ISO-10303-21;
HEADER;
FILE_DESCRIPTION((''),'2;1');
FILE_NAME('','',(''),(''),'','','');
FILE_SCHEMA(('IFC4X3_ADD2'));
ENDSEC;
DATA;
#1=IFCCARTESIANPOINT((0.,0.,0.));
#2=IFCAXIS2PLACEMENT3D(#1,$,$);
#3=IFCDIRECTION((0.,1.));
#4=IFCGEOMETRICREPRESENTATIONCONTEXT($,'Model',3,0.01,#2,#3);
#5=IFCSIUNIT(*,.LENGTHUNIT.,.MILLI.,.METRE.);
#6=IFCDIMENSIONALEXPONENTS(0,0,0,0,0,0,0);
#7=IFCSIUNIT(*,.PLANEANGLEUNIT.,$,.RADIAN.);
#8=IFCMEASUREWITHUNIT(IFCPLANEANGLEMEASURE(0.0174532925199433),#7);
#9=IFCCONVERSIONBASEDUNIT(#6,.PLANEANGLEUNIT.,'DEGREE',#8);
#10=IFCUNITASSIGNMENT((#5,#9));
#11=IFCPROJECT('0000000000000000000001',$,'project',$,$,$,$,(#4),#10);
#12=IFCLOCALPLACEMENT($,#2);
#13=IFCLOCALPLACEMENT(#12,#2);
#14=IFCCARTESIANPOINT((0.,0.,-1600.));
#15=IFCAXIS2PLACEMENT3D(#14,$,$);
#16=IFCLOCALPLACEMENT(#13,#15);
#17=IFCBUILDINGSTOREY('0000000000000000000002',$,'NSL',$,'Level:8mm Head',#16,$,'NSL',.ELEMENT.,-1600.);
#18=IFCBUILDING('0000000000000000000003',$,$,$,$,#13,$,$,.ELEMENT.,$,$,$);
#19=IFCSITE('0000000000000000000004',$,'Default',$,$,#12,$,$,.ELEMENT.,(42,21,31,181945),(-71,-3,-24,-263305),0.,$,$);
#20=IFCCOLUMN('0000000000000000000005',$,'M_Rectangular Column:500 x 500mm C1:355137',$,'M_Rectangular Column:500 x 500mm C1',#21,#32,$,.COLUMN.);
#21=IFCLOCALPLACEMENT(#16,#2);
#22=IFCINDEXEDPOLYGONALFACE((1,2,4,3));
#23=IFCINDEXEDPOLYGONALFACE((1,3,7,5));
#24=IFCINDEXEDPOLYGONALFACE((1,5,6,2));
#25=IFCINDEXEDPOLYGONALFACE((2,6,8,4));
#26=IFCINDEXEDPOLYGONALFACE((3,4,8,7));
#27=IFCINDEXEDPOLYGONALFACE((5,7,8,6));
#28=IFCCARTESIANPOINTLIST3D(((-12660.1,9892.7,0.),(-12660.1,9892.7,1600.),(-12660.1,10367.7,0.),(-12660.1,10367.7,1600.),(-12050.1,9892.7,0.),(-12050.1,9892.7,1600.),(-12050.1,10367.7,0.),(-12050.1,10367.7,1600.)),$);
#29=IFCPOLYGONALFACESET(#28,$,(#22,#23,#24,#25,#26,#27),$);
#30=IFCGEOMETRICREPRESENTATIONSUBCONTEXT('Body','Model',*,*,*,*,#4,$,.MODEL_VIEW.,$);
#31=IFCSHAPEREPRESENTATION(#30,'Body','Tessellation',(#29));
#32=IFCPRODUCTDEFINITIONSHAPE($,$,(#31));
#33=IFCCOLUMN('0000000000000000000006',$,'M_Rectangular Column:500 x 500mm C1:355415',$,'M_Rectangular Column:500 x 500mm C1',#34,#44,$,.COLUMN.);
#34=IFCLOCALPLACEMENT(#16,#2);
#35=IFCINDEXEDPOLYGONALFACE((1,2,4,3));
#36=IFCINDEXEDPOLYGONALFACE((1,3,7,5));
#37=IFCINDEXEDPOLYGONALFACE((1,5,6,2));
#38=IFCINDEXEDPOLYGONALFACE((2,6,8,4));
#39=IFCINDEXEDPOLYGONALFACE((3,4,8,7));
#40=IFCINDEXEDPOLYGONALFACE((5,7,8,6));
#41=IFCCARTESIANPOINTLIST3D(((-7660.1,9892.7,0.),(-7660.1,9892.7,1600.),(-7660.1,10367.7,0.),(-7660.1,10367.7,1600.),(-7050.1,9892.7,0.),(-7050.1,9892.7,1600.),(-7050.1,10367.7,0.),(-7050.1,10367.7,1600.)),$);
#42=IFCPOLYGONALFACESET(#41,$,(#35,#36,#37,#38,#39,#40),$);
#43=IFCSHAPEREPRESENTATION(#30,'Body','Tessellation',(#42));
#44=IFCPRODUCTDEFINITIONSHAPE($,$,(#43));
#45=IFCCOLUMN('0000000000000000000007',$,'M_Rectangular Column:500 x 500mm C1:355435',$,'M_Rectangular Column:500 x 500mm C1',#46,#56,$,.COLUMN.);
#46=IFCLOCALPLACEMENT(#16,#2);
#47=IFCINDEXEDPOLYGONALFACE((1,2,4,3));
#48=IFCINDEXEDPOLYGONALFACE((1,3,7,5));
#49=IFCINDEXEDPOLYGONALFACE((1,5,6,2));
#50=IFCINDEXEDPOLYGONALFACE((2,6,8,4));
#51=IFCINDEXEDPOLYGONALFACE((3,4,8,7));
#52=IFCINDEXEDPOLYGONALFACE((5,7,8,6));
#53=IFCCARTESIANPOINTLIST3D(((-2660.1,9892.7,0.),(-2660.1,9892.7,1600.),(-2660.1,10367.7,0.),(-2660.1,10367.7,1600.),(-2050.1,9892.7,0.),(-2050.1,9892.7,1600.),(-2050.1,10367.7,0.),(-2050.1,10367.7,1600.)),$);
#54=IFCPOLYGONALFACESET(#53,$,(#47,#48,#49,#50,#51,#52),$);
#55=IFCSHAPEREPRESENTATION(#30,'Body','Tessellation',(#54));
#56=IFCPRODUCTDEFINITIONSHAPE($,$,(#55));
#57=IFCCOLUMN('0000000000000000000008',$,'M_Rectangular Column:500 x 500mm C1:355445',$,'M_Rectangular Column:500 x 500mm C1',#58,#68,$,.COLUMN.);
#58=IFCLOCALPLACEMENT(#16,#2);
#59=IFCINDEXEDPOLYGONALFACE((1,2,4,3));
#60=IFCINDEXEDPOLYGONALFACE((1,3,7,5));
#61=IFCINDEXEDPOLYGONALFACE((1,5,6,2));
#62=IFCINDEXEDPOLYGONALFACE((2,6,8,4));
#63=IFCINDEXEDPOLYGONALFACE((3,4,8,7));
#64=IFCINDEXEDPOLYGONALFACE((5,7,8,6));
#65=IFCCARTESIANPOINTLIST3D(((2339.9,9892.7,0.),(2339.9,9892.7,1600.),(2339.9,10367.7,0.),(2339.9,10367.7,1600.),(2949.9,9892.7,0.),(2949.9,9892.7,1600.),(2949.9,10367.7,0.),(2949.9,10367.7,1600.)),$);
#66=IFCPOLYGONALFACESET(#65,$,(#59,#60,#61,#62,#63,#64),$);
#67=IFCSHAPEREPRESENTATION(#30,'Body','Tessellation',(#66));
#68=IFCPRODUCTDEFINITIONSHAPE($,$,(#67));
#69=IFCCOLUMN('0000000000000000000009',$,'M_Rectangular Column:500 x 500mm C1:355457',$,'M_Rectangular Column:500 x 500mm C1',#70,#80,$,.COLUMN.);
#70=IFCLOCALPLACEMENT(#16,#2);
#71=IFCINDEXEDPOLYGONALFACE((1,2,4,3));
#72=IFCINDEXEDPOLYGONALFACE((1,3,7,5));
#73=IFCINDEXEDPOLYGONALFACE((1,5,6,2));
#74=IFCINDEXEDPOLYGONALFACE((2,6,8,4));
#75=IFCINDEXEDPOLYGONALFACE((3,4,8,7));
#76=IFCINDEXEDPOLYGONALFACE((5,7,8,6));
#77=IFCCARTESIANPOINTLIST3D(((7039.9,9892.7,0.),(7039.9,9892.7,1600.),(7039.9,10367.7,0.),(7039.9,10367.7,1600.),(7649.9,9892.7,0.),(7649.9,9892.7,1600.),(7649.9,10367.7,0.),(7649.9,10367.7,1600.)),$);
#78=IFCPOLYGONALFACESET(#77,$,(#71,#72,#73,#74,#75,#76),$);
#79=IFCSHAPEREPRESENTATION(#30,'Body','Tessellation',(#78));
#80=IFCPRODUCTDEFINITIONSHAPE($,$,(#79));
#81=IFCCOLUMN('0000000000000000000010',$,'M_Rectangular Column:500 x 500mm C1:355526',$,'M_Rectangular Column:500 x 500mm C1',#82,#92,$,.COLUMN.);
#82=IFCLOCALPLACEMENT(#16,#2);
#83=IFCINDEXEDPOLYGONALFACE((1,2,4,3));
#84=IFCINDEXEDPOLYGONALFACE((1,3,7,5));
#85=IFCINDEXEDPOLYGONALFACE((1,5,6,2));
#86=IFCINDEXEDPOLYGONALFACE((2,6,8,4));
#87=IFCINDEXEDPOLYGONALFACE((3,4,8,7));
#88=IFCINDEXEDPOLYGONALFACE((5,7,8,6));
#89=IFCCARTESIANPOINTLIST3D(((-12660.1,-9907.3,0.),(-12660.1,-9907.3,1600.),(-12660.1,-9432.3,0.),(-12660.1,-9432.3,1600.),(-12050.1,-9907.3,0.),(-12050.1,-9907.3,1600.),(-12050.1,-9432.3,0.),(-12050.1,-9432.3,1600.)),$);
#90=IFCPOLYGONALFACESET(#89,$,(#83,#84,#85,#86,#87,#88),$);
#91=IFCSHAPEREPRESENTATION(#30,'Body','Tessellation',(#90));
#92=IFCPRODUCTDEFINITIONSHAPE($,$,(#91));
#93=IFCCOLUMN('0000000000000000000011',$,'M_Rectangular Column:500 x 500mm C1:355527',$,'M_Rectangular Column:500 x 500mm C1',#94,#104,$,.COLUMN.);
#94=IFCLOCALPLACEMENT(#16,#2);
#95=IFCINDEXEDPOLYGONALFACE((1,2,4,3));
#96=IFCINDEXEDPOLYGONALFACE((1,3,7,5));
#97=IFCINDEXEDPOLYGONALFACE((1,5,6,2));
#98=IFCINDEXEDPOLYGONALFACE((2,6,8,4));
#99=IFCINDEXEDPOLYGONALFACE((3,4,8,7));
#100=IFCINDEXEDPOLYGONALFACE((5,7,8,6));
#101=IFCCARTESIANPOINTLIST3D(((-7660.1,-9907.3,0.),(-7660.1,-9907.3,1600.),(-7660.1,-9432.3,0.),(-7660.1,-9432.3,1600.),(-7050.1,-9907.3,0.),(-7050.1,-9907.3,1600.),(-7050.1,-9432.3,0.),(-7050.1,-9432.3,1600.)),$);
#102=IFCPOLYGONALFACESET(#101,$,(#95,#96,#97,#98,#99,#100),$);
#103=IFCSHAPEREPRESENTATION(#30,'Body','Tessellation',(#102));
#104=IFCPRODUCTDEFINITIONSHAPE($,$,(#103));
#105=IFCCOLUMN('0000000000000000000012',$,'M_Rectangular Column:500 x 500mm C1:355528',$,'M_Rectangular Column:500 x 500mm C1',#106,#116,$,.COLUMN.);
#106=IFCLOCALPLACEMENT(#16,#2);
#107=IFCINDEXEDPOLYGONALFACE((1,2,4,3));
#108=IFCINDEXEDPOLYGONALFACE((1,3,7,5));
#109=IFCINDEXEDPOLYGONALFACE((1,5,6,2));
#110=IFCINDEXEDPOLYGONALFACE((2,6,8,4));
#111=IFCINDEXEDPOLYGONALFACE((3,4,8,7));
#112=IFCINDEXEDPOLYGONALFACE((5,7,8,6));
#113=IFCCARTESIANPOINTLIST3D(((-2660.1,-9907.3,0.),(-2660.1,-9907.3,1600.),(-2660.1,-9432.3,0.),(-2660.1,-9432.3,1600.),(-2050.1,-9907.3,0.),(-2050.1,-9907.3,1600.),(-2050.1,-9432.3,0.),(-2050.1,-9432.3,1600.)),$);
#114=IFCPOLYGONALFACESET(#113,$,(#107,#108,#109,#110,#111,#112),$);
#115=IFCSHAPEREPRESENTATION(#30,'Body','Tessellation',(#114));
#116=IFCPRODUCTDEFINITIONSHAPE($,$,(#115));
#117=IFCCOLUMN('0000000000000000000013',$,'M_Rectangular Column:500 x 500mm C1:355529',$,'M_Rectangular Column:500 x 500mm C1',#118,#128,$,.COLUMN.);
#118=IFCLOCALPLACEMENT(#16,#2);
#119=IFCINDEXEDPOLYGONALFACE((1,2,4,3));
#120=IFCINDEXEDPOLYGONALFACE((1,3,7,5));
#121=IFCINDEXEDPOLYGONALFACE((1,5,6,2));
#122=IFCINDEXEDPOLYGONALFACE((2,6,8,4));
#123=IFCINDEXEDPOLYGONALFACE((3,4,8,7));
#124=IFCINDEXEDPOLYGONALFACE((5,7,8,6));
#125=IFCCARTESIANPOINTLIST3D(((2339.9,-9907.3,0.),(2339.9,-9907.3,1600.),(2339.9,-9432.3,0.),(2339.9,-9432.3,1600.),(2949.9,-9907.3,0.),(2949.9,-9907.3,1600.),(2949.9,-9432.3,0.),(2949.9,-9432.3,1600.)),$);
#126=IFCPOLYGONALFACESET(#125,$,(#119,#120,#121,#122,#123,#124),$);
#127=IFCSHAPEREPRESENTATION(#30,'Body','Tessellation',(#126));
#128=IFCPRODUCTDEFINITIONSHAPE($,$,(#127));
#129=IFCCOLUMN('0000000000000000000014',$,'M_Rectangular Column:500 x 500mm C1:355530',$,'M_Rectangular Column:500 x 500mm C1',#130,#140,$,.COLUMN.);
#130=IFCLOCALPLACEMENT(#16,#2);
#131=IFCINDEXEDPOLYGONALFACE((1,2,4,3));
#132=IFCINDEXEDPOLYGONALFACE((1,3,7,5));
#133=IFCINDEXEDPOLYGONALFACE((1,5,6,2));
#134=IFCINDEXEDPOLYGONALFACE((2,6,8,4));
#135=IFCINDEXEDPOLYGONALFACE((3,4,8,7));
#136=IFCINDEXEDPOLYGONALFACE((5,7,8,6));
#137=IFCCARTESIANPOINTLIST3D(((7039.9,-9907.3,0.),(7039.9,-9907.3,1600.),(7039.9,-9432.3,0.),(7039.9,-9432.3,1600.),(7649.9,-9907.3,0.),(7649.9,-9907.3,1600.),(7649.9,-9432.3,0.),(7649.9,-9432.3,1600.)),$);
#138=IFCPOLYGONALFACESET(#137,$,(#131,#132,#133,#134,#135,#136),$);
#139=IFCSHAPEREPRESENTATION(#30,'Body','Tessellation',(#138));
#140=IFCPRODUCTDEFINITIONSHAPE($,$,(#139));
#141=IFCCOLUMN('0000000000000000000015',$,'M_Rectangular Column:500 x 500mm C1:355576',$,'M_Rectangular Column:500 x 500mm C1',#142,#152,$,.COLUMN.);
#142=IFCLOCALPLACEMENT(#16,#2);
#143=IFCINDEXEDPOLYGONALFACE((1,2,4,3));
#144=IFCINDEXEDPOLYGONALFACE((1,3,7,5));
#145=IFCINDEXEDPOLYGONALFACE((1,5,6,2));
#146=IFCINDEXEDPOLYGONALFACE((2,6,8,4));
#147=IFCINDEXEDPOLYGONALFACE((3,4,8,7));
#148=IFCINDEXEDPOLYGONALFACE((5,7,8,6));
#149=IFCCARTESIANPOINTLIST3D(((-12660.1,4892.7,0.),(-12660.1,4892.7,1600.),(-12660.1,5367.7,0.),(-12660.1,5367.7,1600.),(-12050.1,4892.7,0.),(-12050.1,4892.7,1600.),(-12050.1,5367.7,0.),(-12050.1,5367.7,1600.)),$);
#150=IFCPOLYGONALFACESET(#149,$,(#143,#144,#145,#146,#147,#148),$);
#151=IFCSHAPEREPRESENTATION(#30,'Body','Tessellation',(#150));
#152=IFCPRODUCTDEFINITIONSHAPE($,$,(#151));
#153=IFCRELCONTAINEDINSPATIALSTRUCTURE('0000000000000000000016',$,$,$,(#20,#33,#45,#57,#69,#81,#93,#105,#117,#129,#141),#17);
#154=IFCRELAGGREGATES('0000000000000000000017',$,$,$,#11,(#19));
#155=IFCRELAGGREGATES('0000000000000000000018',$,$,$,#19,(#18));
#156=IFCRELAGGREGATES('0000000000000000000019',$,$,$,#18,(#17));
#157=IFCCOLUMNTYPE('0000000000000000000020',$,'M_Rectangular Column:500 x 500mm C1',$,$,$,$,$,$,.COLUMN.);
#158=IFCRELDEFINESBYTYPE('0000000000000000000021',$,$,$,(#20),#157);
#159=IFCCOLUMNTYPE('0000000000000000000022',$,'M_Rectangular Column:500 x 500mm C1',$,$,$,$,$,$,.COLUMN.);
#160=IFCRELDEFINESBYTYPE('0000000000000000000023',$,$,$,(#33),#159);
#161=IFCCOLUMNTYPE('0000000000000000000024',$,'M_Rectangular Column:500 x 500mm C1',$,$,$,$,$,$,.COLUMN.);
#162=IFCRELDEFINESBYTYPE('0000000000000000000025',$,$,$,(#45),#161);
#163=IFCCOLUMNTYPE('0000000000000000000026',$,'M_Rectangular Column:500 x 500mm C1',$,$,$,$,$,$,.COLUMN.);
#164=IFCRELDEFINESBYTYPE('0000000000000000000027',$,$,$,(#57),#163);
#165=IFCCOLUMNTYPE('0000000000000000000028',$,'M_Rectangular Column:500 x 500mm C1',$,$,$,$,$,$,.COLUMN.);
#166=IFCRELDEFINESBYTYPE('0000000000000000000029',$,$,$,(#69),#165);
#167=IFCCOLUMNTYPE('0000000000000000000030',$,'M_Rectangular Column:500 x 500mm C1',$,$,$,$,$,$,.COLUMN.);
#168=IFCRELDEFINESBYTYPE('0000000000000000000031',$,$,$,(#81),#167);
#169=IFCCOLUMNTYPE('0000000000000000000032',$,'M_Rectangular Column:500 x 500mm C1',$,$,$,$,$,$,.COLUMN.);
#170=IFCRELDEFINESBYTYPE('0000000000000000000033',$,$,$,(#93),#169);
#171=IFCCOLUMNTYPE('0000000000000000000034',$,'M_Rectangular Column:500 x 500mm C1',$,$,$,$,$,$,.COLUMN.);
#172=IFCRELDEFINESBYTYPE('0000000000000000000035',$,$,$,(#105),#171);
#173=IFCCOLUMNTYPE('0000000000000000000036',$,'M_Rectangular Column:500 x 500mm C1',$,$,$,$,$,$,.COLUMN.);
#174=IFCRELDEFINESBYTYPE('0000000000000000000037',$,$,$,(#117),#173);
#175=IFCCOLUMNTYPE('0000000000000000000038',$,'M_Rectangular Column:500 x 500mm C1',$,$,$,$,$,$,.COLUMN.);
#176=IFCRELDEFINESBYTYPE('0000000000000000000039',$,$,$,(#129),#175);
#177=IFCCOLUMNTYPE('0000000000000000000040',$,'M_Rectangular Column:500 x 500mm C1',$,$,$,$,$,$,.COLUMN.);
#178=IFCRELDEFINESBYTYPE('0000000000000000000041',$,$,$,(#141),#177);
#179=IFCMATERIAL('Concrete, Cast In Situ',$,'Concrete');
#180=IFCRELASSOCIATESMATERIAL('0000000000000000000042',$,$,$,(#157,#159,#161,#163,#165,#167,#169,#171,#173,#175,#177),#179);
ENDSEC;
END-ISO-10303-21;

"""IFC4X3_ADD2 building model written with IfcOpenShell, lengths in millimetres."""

from ifc_helpers import new_model, entity, si_unit, converted_unit, direction, frame, frame_2d, origin, origin_2d_with_axis, place, context, subcontext, project, spatial, rectangle, extrude, source, transform, mapped, material, material_profile, profile_set, type_object, type_shapes, element, save


model = new_model("IFC4X3_ADD2")

# Units and contexts
model_context = context("Model", 3, precision=0.01, world=origin(), true_north=direction((0.0, 1.0)))
body_context = subcontext(model_context, "Body", "Model", "MODEL_VIEW")
ifc_project = project(units=[si_unit("LENGTHUNIT", "METRE", prefix="MILLI"), converted_unit("PLANEANGLEUNIT", "DEGREE", entity("IfcPlaneAngleMeasure", 0.0174532925199433), si_unit("PLANEANGLEUNIT", "RADIAN"), dimensions=[0, 0, 0, 0, 0, 0, 0])], contexts=[model_context])

# Site, building, storey
site_placement = place(None, origin())
site = spatial("IfcSite", under=ifc_project, at=site_placement, Name="Default", CompositionType="ELEMENT", RefLatitude=(42, 21, 31, 181945), RefLongitude=(-71, -3, -24, -263305), RefElevation=0.0)
building_placement = place(site_placement, origin())
building = spatial("IfcBuilding", under=site, at=building_placement, CompositionType="ELEMENT")
storey_placement = place(building_placement, frame((0.0, 0.0, -1600.0)))
storey = spatial("IfcBuildingStorey", under=building, at=storey_placement, Name="NSL", ObjectType="Level:8mm Head", LongName="NSL", CompositionType="ELEMENT", Elevation=-1600.0)

# Columns
ifc_material_1 = material(Name="Concrete, Cast In Situ", Category="Concrete")
ifc_material_profile_1 = material_profile(ifc_material_1, rectangle(XDim=610.0, YDim=475.0, at=frame_2d((0.0, 0.0), x_axis=(1.0, 0.0))), Name="500 x 500mm C1")
ifc_profile_set_1 = profile_set([ifc_material_profile_1], Name="500 x 500mm C1")
column_type_1 = type_object("IfcColumnType", Name="M_Rectangular Column:500 x 500mm C1", PredefinedType="COLUMN", material=ifc_profile_set_1)
shared_shape_1 = source(origin(), body_context, "Body", "SweptSolid", [
    extrude(rectangle(XDim=610.0, YDim=475.0, at=frame_2d((0.0, 0.0), x_axis=(1.0, 0.0))), frame((-12355.1, 10130.2, -1600.0), z_axis=(0.0, 0.0, 1.0), x_axis=(-1.0, 0.0, 0.0)), (0.0, 0.0, 1.0), 1600.0),
])
type_shapes(column_type_1, [shared_shape_1])
column_1_placement = place(storey_placement, frame((0.0, 0.0, 1600.0)))
element("IfcColumn", 1, at=column_1_placement, inside=storey, type_object=column_type_1, Name="M_Rectangular Column:500 x 500mm C1:355137", ObjectType="M_Rectangular Column:500 x 500mm C1", PredefinedType="COLUMN", context=body_context, shape_type="MappedRepresentation", body=[
    mapped(shared_shape_1, transform((0.0, 0.0, 0.0), scale=1.0)),
])
column_type_2 = type_object("IfcColumnType", Name="M_Rectangular Column:500 x 500mm C1", PredefinedType="COLUMN", material=ifc_profile_set_1)
shared_shape_2 = source(origin(), body_context, "Body", "SweptSolid", [
    extrude(rectangle(XDim=610.0, YDim=475.0, at=frame_2d((0.0, 0.0), x_axis=(1.0, 0.0))), frame((-7355.1, 10130.2, -1600.0), z_axis=(0.0, 0.0, 1.0), x_axis=(-1.0, 0.0, 0.0)), (0.0, 0.0, 1.0), 1600.0),
])
type_shapes(column_type_2, [shared_shape_2])
column_2_placement = place(storey_placement, frame((0.0, 0.0, 1600.0)))
element("IfcColumn", 2, at=column_2_placement, inside=storey, type_object=column_type_2, Name="M_Rectangular Column:500 x 500mm C1:355415", ObjectType="M_Rectangular Column:500 x 500mm C1", PredefinedType="COLUMN", context=body_context, shape_type="MappedRepresentation", body=[
    mapped(shared_shape_2, transform((0.0, 0.0, 0.0), scale=1.0)),
])
column_type_3 = type_object("IfcColumnType", Name="M_Rectangular Column:500 x 500mm C1", PredefinedType="COLUMN", material=ifc_profile_set_1)
shared_shape_3 = source(origin(), body_context, "Body", "SweptSolid", [
    extrude(rectangle(XDim=610.0, YDim=475.0, at=frame_2d((0.0, 0.0), x_axis=(1.0, 0.0))), frame((-2355.1, 10130.2, -1600.0), z_axis=(0.0, 0.0, 1.0), x_axis=(-1.0, 0.0, 0.0)), (0.0, 0.0, 1.0), 1600.0),
])
type_shapes(column_type_3, [shared_shape_3])
column_3_placement = place(storey_placement, frame((0.0, 0.0, 1600.0)))
element("IfcColumn", 3, at=column_3_placement, inside=storey, type_object=column_type_3, Name="M_Rectangular Column:500 x 500mm C1:355435", ObjectType="M_Rectangular Column:500 x 500mm C1", PredefinedType="COLUMN", context=body_context, shape_type="MappedRepresentation", body=[
    mapped(shared_shape_3, transform((0.0, 0.0, 0.0), scale=1.0)),
])
column_type_4 = type_object("IfcColumnType", Name="M_Rectangular Column:500 x 500mm C1", PredefinedType="COLUMN", material=ifc_profile_set_1)
shared_shape_4 = source(origin(), body_context, "Body", "SweptSolid", [
    extrude(rectangle(XDim=610.0, YDim=475.0, at=frame_2d((0.0, 0.0), x_axis=(1.0, 0.0))), frame((2644.9, 10130.2, -1600.0), z_axis=(0.0, 0.0, 1.0), x_axis=(-1.0, 0.0, 0.0)), (0.0, 0.0, 1.0), 1600.0),
])
type_shapes(column_type_4, [shared_shape_4])
column_4_placement = place(storey_placement, frame((0.0, 0.0, 1600.0)))
element("IfcColumn", 4, at=column_4_placement, inside=storey, type_object=column_type_4, Name="M_Rectangular Column:500 x 500mm C1:355445", ObjectType="M_Rectangular Column:500 x 500mm C1", PredefinedType="COLUMN", context=body_context, shape_type="MappedRepresentation", body=[
    mapped(shared_shape_4, transform((0.0, 0.0, 0.0), scale=1.0)),
])
column_type_5 = type_object("IfcColumnType", Name="M_Rectangular Column:500 x 500mm C1", PredefinedType="COLUMN", material=ifc_profile_set_1)
shared_shape_5 = source(origin(), body_context, "Body", "SweptSolid", [
    extrude(rectangle(XDim=610.0, YDim=475.0, at=frame_2d((0.0, 0.0), x_axis=(1.0, 0.0))), frame((7344.9, 10130.2, -1600.0), z_axis=(0.0, 0.0, 1.0), x_axis=(-1.0, 0.0, 0.0)), (0.0, 0.0, 1.0), 1600.0),
])
type_shapes(column_type_5, [shared_shape_5])
column_5_placement = place(storey_placement, frame((0.0, 0.0, 1600.0)))
element("IfcColumn", 5, at=column_5_placement, inside=storey, type_object=column_type_5, Name="M_Rectangular Column:500 x 500mm C1:355457", ObjectType="M_Rectangular Column:500 x 500mm C1", PredefinedType="COLUMN", context=body_context, shape_type="MappedRepresentation", body=[
    mapped(shared_shape_5, transform((0.0, 0.0, 0.0), scale=1.0)),
])
column_type_6 = type_object("IfcColumnType", Name="M_Rectangular Column:500 x 500mm C1", PredefinedType="COLUMN", material=ifc_profile_set_1)
shared_shape_6 = source(origin(), body_context, "Body", "SweptSolid", [
    extrude(rectangle(XDim=610.0, YDim=475.0, at=origin_2d_with_axis()), frame((-12355.1, -9669.8, -1600.0), z_axis=(0.0, 0.0, 1.0), x_axis=(-1.0, 0.0, 0.0)), (0.0, 0.0, 1.0), 1600.0),
])
type_shapes(column_type_6, [shared_shape_6])
column_6_placement = place(storey_placement, frame((0.0, 0.0, 1600.0)))
element("IfcColumn", 6, at=column_6_placement, inside=storey, type_object=column_type_6, Name="M_Rectangular Column:500 x 500mm C1:355526", ObjectType="M_Rectangular Column:500 x 500mm C1", PredefinedType="COLUMN", context=body_context, shape_type="MappedRepresentation", body=[
    mapped(shared_shape_6, transform((0.0, 0.0, 0.0), scale=1.0)),
])
column_type_7 = type_object("IfcColumnType", Name="M_Rectangular Column:500 x 500mm C1", PredefinedType="COLUMN", material=ifc_profile_set_1)
shared_shape_7 = source(origin(), body_context, "Body", "SweptSolid", [
    extrude(rectangle(XDim=610.0, YDim=475.0, at=frame_2d((0.0, 0.0), x_axis=(1.0, 0.0))), frame((-7355.1, -9669.8, -1600.0), z_axis=(0.0, 0.0, 1.0), x_axis=(-1.0, 0.0, 0.0)), (0.0, 0.0, 1.0), 1600.0),
])
type_shapes(column_type_7, [shared_shape_7])
column_7_placement = place(storey_placement, frame((0.0, 0.0, 1600.0)))
element("IfcColumn", 7, at=column_7_placement, inside=storey, type_object=column_type_7, Name="M_Rectangular Column:500 x 500mm C1:355527", ObjectType="M_Rectangular Column:500 x 500mm C1", PredefinedType="COLUMN", context=body_context, shape_type="MappedRepresentation", body=[
    mapped(shared_shape_7, transform((0.0, 0.0, 0.0), scale=1.0)),
])
column_type_8 = type_object("IfcColumnType", Name="M_Rectangular Column:500 x 500mm C1", PredefinedType="COLUMN", material=ifc_profile_set_1)
shared_shape_8 = source(origin(), body_context, "Body", "SweptSolid", [
    extrude(rectangle(XDim=610.0, YDim=475.0, at=frame_2d((0.0, 0.0), x_axis=(1.0, 0.0))), frame((-2355.1, -9669.8, -1600.0), z_axis=(0.0, 0.0, 1.0), x_axis=(-1.0, 0.0, 0.0)), (0.0, 0.0, 1.0), 1600.0),
])
type_shapes(column_type_8, [shared_shape_8])
column_8_placement = place(storey_placement, frame((0.0, 0.0, 1600.0)))
element("IfcColumn", 8, at=column_8_placement, inside=storey, type_object=column_type_8, Name="M_Rectangular Column:500 x 500mm C1:355528", ObjectType="M_Rectangular Column:500 x 500mm C1", PredefinedType="COLUMN", context=body_context, shape_type="MappedRepresentation", body=[
    mapped(shared_shape_8, transform((0.0, 0.0, 0.0), scale=1.0)),
])
column_type_9 = type_object("IfcColumnType", Name="M_Rectangular Column:500 x 500mm C1", PredefinedType="COLUMN", material=ifc_profile_set_1)
shared_shape_9 = source(origin(), body_context, "Body", "SweptSolid", [
    extrude(rectangle(XDim=610.0, YDim=475.0, at=frame_2d((0.0, 0.0), x_axis=(1.0, 0.0))), frame((2644.9, -9669.8, -1600.0), z_axis=(0.0, 0.0, 1.0), x_axis=(-1.0, 0.0, 0.0)), (0.0, 0.0, 1.0), 1600.0),
])
type_shapes(column_type_9, [shared_shape_9])
column_9_placement = place(storey_placement, frame((0.0, 0.0, 1600.0)))
element("IfcColumn", 9, at=column_9_placement, inside=storey, type_object=column_type_9, Name="M_Rectangular Column:500 x 500mm C1:355529", ObjectType="M_Rectangular Column:500 x 500mm C1", PredefinedType="COLUMN", context=body_context, shape_type="MappedRepresentation", body=[
    mapped(shared_shape_9, transform((0.0, 0.0, 0.0), scale=1.0)),
])
column_type_10 = type_object("IfcColumnType", Name="M_Rectangular Column:500 x 500mm C1", PredefinedType="COLUMN", material=ifc_profile_set_1)
shared_shape_10 = source(origin(), body_context, "Body", "SweptSolid", [
    extrude(rectangle(XDim=610.0, YDim=475.0, at=origin_2d_with_axis()), frame((7344.9, -9669.8, -1600.0), z_axis=(0.0, 0.0, 1.0), x_axis=(-1.0, 0.0, 0.0)), (0.0, 0.0, 1.0), 1600.0),
])
type_shapes(column_type_10, [shared_shape_10])
column_10_placement = place(storey_placement, frame((0.0, 0.0, 1600.0)))
element("IfcColumn", 10, at=column_10_placement, inside=storey, type_object=column_type_10, Name="M_Rectangular Column:500 x 500mm C1:355530", ObjectType="M_Rectangular Column:500 x 500mm C1", PredefinedType="COLUMN", context=body_context, shape_type="MappedRepresentation", body=[
    mapped(shared_shape_10, transform((0.0, 0.0, 0.0), scale=1.0)),
])
column_type_11 = type_object("IfcColumnType", Name="M_Rectangular Column:500 x 500mm C1", PredefinedType="COLUMN", material=ifc_profile_set_1)
shared_shape_11 = source(origin(), body_context, "Body", "SweptSolid", [
    extrude(rectangle(XDim=610.0, YDim=475.0, at=frame_2d((0.0, 0.0), x_axis=(1.0, 0.0))), frame((-12355.1, 5130.2, -1600.0), z_axis=(0.0, 0.0, 1.0), x_axis=(-1.0, 0.0, 0.0)), (0.0, 0.0, 1.0), 1600.0),
])
type_shapes(column_type_11, [shared_shape_11])
column_11_placement = place(storey_placement, frame((0.0, 0.0, 1600.0)))
element("IfcColumn", 11, at=column_11_placement, inside=storey, type_object=column_type_11, Name="M_Rectangular Column:500 x 500mm C1:355576", ObjectType="M_Rectangular Column:500 x 500mm C1", PredefinedType="COLUMN", context=body_context, shape_type="MappedRepresentation", body=[
    mapped(shared_shape_11, transform((0.0, 0.0, 0.0), scale=1.0)),
])

save(model, "model.ifc")
